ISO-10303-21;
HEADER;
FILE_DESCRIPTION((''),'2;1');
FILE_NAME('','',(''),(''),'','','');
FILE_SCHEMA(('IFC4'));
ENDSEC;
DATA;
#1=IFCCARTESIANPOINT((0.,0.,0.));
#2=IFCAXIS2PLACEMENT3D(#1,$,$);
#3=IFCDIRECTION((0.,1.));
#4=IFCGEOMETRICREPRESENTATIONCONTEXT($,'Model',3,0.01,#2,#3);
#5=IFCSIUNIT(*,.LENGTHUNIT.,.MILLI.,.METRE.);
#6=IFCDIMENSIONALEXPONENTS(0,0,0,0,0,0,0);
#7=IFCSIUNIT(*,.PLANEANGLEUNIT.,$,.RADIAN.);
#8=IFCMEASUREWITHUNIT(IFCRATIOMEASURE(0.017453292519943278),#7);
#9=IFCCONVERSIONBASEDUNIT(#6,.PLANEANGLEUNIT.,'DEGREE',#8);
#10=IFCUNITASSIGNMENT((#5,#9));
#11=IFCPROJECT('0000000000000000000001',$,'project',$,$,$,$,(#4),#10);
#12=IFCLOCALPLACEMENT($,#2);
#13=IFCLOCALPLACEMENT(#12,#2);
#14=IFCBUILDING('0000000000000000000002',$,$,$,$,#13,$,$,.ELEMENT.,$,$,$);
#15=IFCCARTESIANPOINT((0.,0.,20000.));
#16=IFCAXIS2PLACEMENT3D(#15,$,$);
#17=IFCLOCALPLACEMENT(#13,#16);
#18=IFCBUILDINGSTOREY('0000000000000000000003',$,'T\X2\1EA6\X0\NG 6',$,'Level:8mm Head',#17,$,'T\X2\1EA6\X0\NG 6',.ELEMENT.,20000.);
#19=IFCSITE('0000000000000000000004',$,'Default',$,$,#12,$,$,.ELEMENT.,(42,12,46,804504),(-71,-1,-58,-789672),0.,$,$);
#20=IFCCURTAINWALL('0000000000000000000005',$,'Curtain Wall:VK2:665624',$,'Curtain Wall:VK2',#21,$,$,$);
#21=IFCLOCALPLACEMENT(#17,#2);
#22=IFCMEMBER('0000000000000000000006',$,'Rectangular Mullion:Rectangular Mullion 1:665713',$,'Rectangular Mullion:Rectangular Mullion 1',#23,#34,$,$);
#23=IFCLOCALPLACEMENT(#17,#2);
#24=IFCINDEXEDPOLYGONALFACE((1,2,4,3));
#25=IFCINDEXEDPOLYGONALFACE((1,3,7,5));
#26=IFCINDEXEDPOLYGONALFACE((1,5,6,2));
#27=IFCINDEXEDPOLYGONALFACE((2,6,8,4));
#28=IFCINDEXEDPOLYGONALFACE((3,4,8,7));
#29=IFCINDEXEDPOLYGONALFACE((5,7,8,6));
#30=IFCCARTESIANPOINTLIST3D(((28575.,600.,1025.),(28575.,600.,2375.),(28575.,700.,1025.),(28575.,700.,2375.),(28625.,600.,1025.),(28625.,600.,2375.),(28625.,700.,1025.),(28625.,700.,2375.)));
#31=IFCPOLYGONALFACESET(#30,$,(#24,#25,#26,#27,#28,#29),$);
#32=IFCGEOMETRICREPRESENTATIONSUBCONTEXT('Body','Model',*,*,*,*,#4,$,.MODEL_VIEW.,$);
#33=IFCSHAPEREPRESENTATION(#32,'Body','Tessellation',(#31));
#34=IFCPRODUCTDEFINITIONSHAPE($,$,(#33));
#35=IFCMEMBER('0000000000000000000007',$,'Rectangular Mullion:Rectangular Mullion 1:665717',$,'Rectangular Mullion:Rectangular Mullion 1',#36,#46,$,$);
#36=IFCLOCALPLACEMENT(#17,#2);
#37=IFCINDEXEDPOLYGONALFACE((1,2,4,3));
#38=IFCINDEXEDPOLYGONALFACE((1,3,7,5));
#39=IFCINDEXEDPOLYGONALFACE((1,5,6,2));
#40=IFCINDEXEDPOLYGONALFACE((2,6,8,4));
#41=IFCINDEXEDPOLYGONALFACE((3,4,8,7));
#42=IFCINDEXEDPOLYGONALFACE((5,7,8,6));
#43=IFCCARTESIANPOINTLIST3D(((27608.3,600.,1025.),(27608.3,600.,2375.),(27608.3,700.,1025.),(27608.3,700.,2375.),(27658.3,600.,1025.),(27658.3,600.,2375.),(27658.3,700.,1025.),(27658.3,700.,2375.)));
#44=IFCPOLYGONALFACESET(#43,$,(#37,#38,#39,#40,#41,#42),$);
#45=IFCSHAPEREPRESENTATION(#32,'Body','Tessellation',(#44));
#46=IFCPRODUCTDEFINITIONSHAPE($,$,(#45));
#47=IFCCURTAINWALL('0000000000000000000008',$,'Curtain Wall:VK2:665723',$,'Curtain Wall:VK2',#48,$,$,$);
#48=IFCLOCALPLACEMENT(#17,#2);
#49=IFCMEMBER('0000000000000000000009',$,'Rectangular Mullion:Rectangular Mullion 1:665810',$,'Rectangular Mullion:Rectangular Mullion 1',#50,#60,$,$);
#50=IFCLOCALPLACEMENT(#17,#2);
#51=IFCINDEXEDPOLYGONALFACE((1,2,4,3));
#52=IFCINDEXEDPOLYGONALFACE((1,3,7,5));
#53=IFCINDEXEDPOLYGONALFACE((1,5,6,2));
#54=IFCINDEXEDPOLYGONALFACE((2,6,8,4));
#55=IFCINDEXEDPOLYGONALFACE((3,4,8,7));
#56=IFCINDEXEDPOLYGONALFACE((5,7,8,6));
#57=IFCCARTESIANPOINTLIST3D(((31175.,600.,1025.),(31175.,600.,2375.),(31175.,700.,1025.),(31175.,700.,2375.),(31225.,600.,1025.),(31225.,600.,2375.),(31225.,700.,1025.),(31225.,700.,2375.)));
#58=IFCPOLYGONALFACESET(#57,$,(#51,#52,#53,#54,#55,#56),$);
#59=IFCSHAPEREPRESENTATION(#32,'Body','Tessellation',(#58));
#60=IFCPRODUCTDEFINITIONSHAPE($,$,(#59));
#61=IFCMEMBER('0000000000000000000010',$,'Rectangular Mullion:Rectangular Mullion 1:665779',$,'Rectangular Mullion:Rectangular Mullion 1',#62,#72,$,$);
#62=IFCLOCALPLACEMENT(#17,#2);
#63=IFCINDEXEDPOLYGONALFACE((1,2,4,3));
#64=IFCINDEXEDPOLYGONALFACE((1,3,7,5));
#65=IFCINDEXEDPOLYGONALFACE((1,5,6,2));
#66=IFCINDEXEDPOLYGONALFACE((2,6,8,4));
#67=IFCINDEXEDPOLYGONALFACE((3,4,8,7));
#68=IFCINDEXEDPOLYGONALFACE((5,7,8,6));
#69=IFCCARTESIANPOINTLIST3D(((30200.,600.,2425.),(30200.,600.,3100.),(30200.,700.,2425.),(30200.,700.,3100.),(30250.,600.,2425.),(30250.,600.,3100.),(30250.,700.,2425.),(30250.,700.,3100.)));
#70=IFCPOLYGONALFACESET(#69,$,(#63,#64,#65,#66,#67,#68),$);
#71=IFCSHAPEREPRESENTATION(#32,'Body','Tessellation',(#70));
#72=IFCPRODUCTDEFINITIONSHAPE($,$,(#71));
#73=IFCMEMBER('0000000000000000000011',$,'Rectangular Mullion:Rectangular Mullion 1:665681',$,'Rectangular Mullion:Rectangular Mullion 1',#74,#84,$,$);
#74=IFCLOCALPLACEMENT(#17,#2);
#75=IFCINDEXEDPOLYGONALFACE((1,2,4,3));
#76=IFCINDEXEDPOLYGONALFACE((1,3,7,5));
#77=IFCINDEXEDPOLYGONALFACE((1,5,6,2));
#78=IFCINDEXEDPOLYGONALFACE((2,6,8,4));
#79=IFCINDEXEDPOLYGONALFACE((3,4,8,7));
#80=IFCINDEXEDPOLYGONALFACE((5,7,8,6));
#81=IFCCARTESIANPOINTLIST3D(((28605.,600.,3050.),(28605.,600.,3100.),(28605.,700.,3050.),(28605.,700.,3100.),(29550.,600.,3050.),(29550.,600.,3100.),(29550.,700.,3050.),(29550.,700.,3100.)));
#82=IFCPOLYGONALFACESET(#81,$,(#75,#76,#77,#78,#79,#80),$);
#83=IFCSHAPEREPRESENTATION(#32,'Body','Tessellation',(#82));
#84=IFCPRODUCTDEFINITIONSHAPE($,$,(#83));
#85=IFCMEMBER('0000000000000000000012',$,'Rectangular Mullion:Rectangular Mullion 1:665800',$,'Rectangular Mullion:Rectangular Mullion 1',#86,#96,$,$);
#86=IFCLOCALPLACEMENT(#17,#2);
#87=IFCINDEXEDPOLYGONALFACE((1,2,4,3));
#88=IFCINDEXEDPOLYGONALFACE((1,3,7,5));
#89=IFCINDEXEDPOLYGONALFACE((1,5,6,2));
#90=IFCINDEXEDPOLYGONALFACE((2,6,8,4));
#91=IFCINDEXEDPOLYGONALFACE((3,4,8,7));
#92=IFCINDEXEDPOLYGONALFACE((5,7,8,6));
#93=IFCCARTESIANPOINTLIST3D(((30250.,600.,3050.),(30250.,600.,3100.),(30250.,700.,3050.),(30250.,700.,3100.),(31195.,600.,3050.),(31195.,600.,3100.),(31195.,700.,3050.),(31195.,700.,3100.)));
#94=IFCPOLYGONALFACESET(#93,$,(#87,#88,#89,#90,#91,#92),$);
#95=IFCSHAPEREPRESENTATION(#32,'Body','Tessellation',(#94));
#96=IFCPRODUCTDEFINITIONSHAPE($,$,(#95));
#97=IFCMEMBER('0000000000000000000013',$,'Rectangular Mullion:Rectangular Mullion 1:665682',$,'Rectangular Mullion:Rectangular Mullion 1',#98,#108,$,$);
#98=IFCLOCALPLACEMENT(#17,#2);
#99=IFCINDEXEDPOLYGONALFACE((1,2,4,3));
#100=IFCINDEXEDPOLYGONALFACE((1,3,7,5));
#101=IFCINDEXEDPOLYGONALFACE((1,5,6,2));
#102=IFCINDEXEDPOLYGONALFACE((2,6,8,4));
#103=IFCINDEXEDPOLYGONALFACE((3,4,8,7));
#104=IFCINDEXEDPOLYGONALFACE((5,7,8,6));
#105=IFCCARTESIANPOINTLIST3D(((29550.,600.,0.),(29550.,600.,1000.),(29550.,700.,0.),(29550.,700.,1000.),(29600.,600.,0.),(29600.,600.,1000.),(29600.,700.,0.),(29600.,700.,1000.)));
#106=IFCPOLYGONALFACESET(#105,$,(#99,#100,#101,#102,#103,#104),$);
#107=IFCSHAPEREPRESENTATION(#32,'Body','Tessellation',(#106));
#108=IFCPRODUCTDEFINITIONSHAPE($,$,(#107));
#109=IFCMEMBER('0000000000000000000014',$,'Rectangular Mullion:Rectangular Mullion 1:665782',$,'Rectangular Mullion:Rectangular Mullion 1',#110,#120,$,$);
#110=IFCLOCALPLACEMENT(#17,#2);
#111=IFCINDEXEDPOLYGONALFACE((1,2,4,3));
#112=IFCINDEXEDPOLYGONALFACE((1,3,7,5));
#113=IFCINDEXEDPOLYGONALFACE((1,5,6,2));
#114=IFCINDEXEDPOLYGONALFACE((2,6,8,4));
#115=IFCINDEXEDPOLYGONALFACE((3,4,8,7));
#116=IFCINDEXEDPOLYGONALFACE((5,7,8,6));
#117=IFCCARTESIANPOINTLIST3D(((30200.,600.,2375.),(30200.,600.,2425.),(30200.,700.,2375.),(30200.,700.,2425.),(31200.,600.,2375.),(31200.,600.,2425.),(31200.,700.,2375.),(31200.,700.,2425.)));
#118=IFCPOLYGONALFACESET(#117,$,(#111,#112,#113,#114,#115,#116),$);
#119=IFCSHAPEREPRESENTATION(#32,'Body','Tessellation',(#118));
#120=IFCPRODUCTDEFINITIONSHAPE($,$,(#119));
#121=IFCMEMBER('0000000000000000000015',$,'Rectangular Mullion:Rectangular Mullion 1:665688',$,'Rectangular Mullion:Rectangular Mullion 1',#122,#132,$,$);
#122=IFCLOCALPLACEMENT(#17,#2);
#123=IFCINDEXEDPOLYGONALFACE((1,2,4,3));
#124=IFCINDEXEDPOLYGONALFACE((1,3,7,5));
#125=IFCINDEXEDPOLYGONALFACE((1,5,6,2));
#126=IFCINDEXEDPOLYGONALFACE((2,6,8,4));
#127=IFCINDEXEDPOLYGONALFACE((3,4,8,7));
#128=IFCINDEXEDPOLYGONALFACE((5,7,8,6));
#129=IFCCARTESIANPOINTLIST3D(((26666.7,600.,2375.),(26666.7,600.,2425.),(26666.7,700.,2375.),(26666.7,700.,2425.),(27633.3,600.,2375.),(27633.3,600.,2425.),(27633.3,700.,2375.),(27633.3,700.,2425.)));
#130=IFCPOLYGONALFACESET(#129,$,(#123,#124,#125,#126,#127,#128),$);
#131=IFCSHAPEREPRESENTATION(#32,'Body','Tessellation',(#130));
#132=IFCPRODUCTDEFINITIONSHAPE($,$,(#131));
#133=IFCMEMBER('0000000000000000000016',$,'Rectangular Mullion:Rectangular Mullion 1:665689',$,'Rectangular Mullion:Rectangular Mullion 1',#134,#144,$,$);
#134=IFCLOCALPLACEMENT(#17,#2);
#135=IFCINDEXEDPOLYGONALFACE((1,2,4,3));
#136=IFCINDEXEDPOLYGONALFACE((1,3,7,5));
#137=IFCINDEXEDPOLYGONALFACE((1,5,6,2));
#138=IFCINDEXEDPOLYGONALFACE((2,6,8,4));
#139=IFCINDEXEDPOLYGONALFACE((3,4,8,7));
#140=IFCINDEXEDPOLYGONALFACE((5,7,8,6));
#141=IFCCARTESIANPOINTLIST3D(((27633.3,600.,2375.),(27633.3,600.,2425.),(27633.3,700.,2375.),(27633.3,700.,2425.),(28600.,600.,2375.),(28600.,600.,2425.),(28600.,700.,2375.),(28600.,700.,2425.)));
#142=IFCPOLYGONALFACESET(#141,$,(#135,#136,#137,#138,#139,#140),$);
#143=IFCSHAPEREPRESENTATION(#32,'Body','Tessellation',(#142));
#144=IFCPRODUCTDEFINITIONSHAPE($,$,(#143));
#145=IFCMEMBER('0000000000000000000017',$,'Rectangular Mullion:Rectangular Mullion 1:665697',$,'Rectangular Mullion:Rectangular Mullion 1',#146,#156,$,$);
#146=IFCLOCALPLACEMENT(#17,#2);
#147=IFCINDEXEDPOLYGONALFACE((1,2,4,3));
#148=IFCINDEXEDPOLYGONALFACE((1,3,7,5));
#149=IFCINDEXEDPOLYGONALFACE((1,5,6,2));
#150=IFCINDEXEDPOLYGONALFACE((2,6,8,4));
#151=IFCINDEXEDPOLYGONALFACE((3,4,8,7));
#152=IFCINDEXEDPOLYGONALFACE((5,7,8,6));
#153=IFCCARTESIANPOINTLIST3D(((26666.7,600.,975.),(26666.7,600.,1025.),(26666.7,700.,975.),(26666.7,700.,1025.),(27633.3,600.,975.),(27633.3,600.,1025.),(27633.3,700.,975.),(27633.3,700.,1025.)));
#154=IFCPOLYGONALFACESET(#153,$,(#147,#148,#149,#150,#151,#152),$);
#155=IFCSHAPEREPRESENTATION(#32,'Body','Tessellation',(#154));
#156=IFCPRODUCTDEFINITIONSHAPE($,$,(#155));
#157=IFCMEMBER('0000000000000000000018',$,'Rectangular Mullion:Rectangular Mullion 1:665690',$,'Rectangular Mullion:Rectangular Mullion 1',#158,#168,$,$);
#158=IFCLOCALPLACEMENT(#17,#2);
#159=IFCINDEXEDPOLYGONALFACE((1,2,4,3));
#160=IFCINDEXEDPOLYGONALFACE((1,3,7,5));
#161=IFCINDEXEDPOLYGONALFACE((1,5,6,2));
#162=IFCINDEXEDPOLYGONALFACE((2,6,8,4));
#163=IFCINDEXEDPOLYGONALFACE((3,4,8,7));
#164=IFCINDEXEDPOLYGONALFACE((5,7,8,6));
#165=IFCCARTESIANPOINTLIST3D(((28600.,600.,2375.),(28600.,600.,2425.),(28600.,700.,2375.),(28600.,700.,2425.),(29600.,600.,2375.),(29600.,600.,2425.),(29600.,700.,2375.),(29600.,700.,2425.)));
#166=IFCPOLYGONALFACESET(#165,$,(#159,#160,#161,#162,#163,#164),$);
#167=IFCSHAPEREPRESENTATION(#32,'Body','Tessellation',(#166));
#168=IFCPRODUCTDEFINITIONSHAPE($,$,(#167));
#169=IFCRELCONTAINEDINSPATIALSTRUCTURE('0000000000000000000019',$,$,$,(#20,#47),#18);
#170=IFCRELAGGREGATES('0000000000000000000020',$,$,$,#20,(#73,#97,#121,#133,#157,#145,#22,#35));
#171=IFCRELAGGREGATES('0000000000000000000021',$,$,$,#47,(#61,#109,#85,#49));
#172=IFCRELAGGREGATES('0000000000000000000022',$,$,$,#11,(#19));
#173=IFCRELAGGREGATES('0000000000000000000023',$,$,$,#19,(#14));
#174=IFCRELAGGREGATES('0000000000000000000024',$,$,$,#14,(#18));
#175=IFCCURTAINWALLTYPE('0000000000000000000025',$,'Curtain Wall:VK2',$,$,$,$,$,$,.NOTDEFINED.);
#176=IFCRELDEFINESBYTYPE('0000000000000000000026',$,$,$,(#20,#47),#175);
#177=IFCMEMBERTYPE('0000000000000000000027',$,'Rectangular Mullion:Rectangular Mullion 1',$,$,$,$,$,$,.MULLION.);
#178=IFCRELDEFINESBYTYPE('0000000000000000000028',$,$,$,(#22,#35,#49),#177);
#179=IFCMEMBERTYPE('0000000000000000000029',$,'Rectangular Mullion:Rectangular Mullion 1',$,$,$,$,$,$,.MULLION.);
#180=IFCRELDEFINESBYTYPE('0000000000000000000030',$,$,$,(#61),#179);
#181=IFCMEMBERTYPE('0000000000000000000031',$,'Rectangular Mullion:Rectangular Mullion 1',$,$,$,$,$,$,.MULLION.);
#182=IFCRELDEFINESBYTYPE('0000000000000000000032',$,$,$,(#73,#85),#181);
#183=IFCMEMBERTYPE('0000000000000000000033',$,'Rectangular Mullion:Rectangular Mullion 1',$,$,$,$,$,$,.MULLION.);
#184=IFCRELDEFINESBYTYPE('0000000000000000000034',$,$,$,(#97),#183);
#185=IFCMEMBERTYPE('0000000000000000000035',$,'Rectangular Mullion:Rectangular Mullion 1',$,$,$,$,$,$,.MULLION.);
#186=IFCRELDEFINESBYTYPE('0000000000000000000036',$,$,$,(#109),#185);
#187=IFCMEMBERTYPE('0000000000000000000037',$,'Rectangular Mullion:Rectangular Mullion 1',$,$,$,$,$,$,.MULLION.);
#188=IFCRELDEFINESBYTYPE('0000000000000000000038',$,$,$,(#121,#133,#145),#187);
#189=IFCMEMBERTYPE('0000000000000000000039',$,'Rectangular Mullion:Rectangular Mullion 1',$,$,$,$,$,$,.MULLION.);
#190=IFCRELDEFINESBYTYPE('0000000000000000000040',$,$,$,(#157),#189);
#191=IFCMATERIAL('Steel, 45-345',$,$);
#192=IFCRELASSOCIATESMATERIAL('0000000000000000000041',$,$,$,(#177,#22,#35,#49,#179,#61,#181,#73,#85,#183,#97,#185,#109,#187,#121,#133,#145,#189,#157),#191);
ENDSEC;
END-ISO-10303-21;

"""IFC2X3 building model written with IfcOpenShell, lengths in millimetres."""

from ifc_helpers import new_model, entity, si_unit, converted_unit, direction, frame, origin, origin_2d_with_axis, place, context, subcontext, project, spatial, rectangle, extrude, source, transform, mapped, material, type_object, type_shapes, element, aggregate, save


model = new_model("IFC2X3")

# Units and contexts
model_context = context("Model", 3, precision=0.01, world=origin(), true_north=direction((0.0, 1.0)))
body_context = subcontext(model_context, "Body", "Model", "MODEL_VIEW")
ifc_project = project(units=[si_unit("LENGTHUNIT", "METRE", prefix="MILLI"), converted_unit("PLANEANGLEUNIT", "DEGREE", entity("IfcRatioMeasure", 0.017453292519943278), si_unit("PLANEANGLEUNIT", "RADIAN"), dimensions=[0, 0, 0, 0, 0, 0, 0])], contexts=[model_context])

# Site, building, storey
site_placement = place(None, origin())
site = spatial("IfcSite", under=ifc_project, at=site_placement, Name="Default", CompositionType="ELEMENT", RefLatitude=(42, 12, 46, 804504), RefLongitude=(-71, -1, -58, -789672), RefElevation=0.0)
building_placement = place(site_placement, origin())
building = spatial("IfcBuilding", under=site, at=building_placement, CompositionType="ELEMENT")
storey_placement = place(building_placement, frame((0.0, 0.0, 20000.0)))
storey = spatial("IfcBuildingStorey", under=building, at=storey_placement, Name="TẦNG 6", ObjectType="Level:8mm Head", LongName="TẦNG 6", CompositionType="ELEMENT", Elevation=20000.0)

# Curtain wall, members
curtain_wall_type = type_object("IfcCurtainWallType", Name="Curtain Wall:VK2", PredefinedType="NOTDEFINED")
curtain_wall_1_placement = place(storey_placement, frame((0.0, 0.0, -20000.0)))
curtain_wall_1 = element("IfcCurtainWall", 1, at=curtain_wall_1_placement, inside=storey, type_object=curtain_wall_type, Name="Curtain Wall:VK2:665624", ObjectType="Curtain Wall:VK2")
ifc_material_1 = material(Name="Steel, 45-345")
member_type_1 = type_object("IfcMemberType", Name="Rectangular Mullion:Rectangular Mullion 1", PredefinedType="MULLION", material=ifc_material_1)
shared_shape_1 = source(origin(), body_context, "Body", "SweptSolid", [
    extrude(rectangle(XDim=100.0, YDim=50.0, at=origin_2d_with_axis()), frame((0.0, 50.0, -1350.0), z_axis=(0.0, 0.0, 1.0), x_axis=(0.0, -1.0, 0.0)), (0.0, 0.0, 1.0), 1350.0),
])
type_shapes(member_type_1, [shared_shape_1])
member_1_placement = place(curtain_wall_1_placement, frame((28600.0, 700.0, 21025.0), z_axis=(0.0, 0.0, -1.0), x_axis=(1.0, 0.0, 0.0)))
member_1 = element("IfcMember", 2, at=member_1_placement, type_object=member_type_1, material=ifc_material_1, Name="Rectangular Mullion:Rectangular Mullion 1:665713", ObjectType="Rectangular Mullion:Rectangular Mullion 1", context=body_context, shape_type="MappedRepresentation", body=[
    mapped(shared_shape_1, transform((0.0, 0.0, 0.0), scale=1.0)),
])
member_2_placement = place(curtain_wall_1_placement, frame((27633.3, 700.0, 21025.0), z_axis=(0.0, 0.0, -1.0), x_axis=(1.0, 0.0, 0.0)))
member_2 = element("IfcMember", 3, at=member_2_placement, type_object=member_type_1, material=ifc_material_1, Name="Rectangular Mullion:Rectangular Mullion 1:665717", ObjectType="Rectangular Mullion:Rectangular Mullion 1", context=body_context, shape_type="MappedRepresentation", body=[
    mapped(shared_shape_1, transform((0.0, 0.0, 0.0), scale=1.0)),
])

# Curtain wall, member
curtain_wall_2_placement = place(storey_placement, frame((0.0, 0.0, -20000.0)))
curtain_wall_2 = element("IfcCurtainWall", 4, at=curtain_wall_2_placement, inside=storey, type_object=curtain_wall_type, Name="Curtain Wall:VK2:665723", ObjectType="Curtain Wall:VK2")
member_3_placement = place(curtain_wall_2_placement, frame((31200.0, 700.0, 21025.0), z_axis=(0.0, 0.0, -1.0), x_axis=(1.0, 0.0, 0.0)))
member_3 = element("IfcMember", 5, at=member_3_placement, type_object=member_type_1, material=ifc_material_1, Name="Rectangular Mullion:Rectangular Mullion 1:665810", ObjectType="Rectangular Mullion:Rectangular Mullion 1", context=body_context, shape_type="MappedRepresentation", body=[
    mapped(shared_shape_1, transform((0.0, 0.0, 0.0), scale=1.0)),
])

# Members
member_type_2 = type_object("IfcMemberType", Name="Rectangular Mullion:Rectangular Mullion 1", PredefinedType="MULLION", material=ifc_material_1)
shared_shape_2 = source(origin(), body_context, "Body", "SweptSolid", [
    extrude(rectangle(XDim=100.0, YDim=50.0, at=origin_2d_with_axis()), frame((-25.0, 50.0, -675.0), z_axis=(0.0, 0.0, 1.0), x_axis=(0.0, -1.0, 0.0)), (0.0, 0.0, 1.0), 675.0),
])
type_shapes(member_type_2, [shared_shape_2])
member_4_placement = place(curtain_wall_2_placement, frame((30200.0, 700.0, 23100.0), z_axis=(0.0, 0.0, 1.0), x_axis=(-1.0, 0.0, 0.0)))
member_4 = element("IfcMember", 6, at=member_4_placement, type_object=member_type_2, material=ifc_material_1, Name="Rectangular Mullion:Rectangular Mullion 1:665779", ObjectType="Rectangular Mullion:Rectangular Mullion 1", context=body_context, shape_type="MappedRepresentation", body=[
    mapped(shared_shape_2, transform((0.0, 0.0, 0.0), scale=1.0)),
])
member_type_3 = type_object("IfcMemberType", Name="Rectangular Mullion:Rectangular Mullion 1", PredefinedType="MULLION", material=ifc_material_1)
shared_shape_3 = source(origin(), body_context, "Body", "SweptSolid", [
    extrude(rectangle(XDim=100.0, YDim=50.0, at=origin_2d_with_axis()), frame((-25.0, 50.0, -945.0), z_axis=(0.0, 0.0, 1.0), x_axis=(0.0, -1.0, 0.0)), (0.0, 0.0, 1.0), 945.0),
])
type_shapes(member_type_3, [shared_shape_3])
member_5_placement = place(curtain_wall_1_placement, frame((29550.0, 700.0, 23100.0), z_axis=(1.0, 0.0, 0.0), x_axis=(0.0, 0.0, 1.0)))
member_5 = element("IfcMember", 7, at=member_5_placement, type_object=member_type_3, material=ifc_material_1, Name="Rectangular Mullion:Rectangular Mullion 1:665681", ObjectType="Rectangular Mullion:Rectangular Mullion 1", context=body_context, shape_type="MappedRepresentation", body=[
    mapped(shared_shape_3, transform((0.0, 0.0, 0.0), scale=1.0)),
])
member_6_placement = place(curtain_wall_2_placement, frame((31195.0, 700.0, 23100.0), z_axis=(1.0, 0.0, 0.0), x_axis=(0.0, 0.0, 1.0)))
member_6 = element("IfcMember", 8, at=member_6_placement, type_object=member_type_3, material=ifc_material_1, Name="Rectangular Mullion:Rectangular Mullion 1:665800", ObjectType="Rectangular Mullion:Rectangular Mullion 1", context=body_context, shape_type="MappedRepresentation", body=[
    mapped(shared_shape_3, transform((0.0, 0.0, 0.0), scale=1.0)),
])
member_type_4 = type_object("IfcMemberType", Name="Rectangular Mullion:Rectangular Mullion 1", PredefinedType="MULLION", material=ifc_material_1)
shared_shape_4 = source(origin(), body_context, "Body", "SweptSolid", [
    extrude(rectangle(XDim=100.0, YDim=50.0, at=origin_2d_with_axis()), frame((-25.0, 50.0, -1000.0), z_axis=(0.0, 0.0, 1.0), x_axis=(0.0, -1.0, 0.0)), (0.0, 0.0, 1.0), 1000.0),
])
type_shapes(member_type_4, [shared_shape_4])
member_7_placement = place(curtain_wall_1_placement, frame((29600.0, 700.0, 20000.0), z_axis=(0.0, 0.0, -1.0), x_axis=(1.0, 0.0, 0.0)))
member_7 = element("IfcMember", 9, at=member_7_placement, type_object=member_type_4, material=ifc_material_1, Name="Rectangular Mullion:Rectangular Mullion 1:665682", ObjectType="Rectangular Mullion:Rectangular Mullion 1", context=body_context, shape_type="MappedRepresentation", body=[
    mapped(shared_shape_4, transform((0.0, 0.0, 0.0), scale=1.0)),
])
member_type_5 = type_object("IfcMemberType", Name="Rectangular Mullion:Rectangular Mullion 1", PredefinedType="MULLION", material=ifc_material_1)
shared_shape_5 = source(origin(), body_context, "Body", "SweptSolid", [
    extrude(rectangle(XDim=100.0, YDim=50.0, at=origin_2d_with_axis()), frame((0.0, 50.0, -1000.0), z_axis=(0.0, 0.0, 1.0), x_axis=(0.0, -1.0, 0.0)), (0.0, 0.0, 1.0), 1000.0),
])
type_shapes(member_type_5, [shared_shape_5])
member_8_placement = place(curtain_wall_2_placement, frame((31200.0, 700.0, 22400.0), z_axis=(1.0, 0.0, 0.0), x_axis=(0.0, 0.0, 1.0)))
member_8 = element("IfcMember", 10, at=member_8_placement, type_object=member_type_5, material=ifc_material_1, Name="Rectangular Mullion:Rectangular Mullion 1:665782", ObjectType="Rectangular Mullion:Rectangular Mullion 1", context=body_context, shape_type="MappedRepresentation", body=[
    mapped(shared_shape_5, transform((0.0, 0.0, 0.0), scale=1.0)),
])
member_type_6 = type_object("IfcMemberType", Name="Rectangular Mullion:Rectangular Mullion 1", PredefinedType="MULLION", material=ifc_material_1)
shared_shape_6 = source(origin(), body_context, "Body", "SweptSolid", [
    extrude(rectangle(XDim=100.0, YDim=50.0, at=origin_2d_with_axis()), frame((0.0, 50.0, -966.7), z_axis=(0.0, 0.0, 1.0), x_axis=(0.0, -1.0, 0.0)), (0.0, 0.0, 1.0), 966.7),
])
type_shapes(member_type_6, [shared_shape_6])
member_9_placement = place(curtain_wall_1_placement, frame((27633.3, 700.0, 22400.0), z_axis=(1.0, 0.0, 0.0), x_axis=(0.0, 0.0, 1.0)))
member_9 = element("IfcMember", 11, at=member_9_placement, type_object=member_type_6, material=ifc_material_1, Name="Rectangular Mullion:Rectangular Mullion 1:665688", ObjectType="Rectangular Mullion:Rectangular Mullion 1", context=body_context, shape_type="MappedRepresentation", body=[
    mapped(shared_shape_6, transform((0.0, 0.0, 0.0), scale=1.0)),
])
member_10_placement = place(curtain_wall_1_placement, frame((28600.0, 700.0, 22400.0), z_axis=(1.0, 0.0, 0.0), x_axis=(0.0, 0.0, 1.0)))
member_10 = element("IfcMember", 12, at=member_10_placement, type_object=member_type_6, material=ifc_material_1, Name="Rectangular Mullion:Rectangular Mullion 1:665689", ObjectType="Rectangular Mullion:Rectangular Mullion 1", context=body_context, shape_type="MappedRepresentation", body=[
    mapped(shared_shape_6, transform((0.0, 0.0, 0.0), scale=1.0)),
])
member_11_placement = place(curtain_wall_1_placement, frame((27633.3, 700.0, 21000.0), z_axis=(1.0, 0.0, 0.0), x_axis=(0.0, 0.0, 1.0)))
member_11 = element("IfcMember", 13, at=member_11_placement, type_object=member_type_6, material=ifc_material_1, Name="Rectangular Mullion:Rectangular Mullion 1:665697", ObjectType="Rectangular Mullion:Rectangular Mullion 1", context=body_context, shape_type="MappedRepresentation", body=[
    mapped(shared_shape_6, transform((0.0, 0.0, 0.0), scale=1.0)),
])
member_type_7 = type_object("IfcMemberType", Name="Rectangular Mullion:Rectangular Mullion 1", PredefinedType="MULLION", material=ifc_material_1)
shared_shape_7 = source(origin(), body_context, "Body", "SweptSolid", [
    extrude(rectangle(XDim=100.0, YDim=50.0, at=origin_2d_with_axis()), frame((0.0, 50.0, -1000.0), z_axis=(0.0, 0.0, 1.0), x_axis=(0.0, -1.0, 0.0)), (0.0, 0.0, 1.0), 1000.0),
])
type_shapes(member_type_7, [shared_shape_7])
member_12_placement = place(curtain_wall_1_placement, frame((29600.0, 700.0, 22400.0), z_axis=(1.0, 0.0, 0.0), x_axis=(0.0, 0.0, 1.0)))
member_12 = element("IfcMember", 14, at=member_12_placement, type_object=member_type_7, material=ifc_material_1, Name="Rectangular Mullion:Rectangular Mullion 1:665690", ObjectType="Rectangular Mullion:Rectangular Mullion 1", context=body_context, shape_type="MappedRepresentation", body=[
    mapped(shared_shape_7, transform((0.0, 0.0, 0.0), scale=1.0)),
])

aggregate(curtain_wall_1, [member_5, member_7, member_9, member_10, member_12, member_11, member_1, member_2])
aggregate(curtain_wall_2, [member_4, member_8, member_6, member_3])

save(model, "model.ifc")
